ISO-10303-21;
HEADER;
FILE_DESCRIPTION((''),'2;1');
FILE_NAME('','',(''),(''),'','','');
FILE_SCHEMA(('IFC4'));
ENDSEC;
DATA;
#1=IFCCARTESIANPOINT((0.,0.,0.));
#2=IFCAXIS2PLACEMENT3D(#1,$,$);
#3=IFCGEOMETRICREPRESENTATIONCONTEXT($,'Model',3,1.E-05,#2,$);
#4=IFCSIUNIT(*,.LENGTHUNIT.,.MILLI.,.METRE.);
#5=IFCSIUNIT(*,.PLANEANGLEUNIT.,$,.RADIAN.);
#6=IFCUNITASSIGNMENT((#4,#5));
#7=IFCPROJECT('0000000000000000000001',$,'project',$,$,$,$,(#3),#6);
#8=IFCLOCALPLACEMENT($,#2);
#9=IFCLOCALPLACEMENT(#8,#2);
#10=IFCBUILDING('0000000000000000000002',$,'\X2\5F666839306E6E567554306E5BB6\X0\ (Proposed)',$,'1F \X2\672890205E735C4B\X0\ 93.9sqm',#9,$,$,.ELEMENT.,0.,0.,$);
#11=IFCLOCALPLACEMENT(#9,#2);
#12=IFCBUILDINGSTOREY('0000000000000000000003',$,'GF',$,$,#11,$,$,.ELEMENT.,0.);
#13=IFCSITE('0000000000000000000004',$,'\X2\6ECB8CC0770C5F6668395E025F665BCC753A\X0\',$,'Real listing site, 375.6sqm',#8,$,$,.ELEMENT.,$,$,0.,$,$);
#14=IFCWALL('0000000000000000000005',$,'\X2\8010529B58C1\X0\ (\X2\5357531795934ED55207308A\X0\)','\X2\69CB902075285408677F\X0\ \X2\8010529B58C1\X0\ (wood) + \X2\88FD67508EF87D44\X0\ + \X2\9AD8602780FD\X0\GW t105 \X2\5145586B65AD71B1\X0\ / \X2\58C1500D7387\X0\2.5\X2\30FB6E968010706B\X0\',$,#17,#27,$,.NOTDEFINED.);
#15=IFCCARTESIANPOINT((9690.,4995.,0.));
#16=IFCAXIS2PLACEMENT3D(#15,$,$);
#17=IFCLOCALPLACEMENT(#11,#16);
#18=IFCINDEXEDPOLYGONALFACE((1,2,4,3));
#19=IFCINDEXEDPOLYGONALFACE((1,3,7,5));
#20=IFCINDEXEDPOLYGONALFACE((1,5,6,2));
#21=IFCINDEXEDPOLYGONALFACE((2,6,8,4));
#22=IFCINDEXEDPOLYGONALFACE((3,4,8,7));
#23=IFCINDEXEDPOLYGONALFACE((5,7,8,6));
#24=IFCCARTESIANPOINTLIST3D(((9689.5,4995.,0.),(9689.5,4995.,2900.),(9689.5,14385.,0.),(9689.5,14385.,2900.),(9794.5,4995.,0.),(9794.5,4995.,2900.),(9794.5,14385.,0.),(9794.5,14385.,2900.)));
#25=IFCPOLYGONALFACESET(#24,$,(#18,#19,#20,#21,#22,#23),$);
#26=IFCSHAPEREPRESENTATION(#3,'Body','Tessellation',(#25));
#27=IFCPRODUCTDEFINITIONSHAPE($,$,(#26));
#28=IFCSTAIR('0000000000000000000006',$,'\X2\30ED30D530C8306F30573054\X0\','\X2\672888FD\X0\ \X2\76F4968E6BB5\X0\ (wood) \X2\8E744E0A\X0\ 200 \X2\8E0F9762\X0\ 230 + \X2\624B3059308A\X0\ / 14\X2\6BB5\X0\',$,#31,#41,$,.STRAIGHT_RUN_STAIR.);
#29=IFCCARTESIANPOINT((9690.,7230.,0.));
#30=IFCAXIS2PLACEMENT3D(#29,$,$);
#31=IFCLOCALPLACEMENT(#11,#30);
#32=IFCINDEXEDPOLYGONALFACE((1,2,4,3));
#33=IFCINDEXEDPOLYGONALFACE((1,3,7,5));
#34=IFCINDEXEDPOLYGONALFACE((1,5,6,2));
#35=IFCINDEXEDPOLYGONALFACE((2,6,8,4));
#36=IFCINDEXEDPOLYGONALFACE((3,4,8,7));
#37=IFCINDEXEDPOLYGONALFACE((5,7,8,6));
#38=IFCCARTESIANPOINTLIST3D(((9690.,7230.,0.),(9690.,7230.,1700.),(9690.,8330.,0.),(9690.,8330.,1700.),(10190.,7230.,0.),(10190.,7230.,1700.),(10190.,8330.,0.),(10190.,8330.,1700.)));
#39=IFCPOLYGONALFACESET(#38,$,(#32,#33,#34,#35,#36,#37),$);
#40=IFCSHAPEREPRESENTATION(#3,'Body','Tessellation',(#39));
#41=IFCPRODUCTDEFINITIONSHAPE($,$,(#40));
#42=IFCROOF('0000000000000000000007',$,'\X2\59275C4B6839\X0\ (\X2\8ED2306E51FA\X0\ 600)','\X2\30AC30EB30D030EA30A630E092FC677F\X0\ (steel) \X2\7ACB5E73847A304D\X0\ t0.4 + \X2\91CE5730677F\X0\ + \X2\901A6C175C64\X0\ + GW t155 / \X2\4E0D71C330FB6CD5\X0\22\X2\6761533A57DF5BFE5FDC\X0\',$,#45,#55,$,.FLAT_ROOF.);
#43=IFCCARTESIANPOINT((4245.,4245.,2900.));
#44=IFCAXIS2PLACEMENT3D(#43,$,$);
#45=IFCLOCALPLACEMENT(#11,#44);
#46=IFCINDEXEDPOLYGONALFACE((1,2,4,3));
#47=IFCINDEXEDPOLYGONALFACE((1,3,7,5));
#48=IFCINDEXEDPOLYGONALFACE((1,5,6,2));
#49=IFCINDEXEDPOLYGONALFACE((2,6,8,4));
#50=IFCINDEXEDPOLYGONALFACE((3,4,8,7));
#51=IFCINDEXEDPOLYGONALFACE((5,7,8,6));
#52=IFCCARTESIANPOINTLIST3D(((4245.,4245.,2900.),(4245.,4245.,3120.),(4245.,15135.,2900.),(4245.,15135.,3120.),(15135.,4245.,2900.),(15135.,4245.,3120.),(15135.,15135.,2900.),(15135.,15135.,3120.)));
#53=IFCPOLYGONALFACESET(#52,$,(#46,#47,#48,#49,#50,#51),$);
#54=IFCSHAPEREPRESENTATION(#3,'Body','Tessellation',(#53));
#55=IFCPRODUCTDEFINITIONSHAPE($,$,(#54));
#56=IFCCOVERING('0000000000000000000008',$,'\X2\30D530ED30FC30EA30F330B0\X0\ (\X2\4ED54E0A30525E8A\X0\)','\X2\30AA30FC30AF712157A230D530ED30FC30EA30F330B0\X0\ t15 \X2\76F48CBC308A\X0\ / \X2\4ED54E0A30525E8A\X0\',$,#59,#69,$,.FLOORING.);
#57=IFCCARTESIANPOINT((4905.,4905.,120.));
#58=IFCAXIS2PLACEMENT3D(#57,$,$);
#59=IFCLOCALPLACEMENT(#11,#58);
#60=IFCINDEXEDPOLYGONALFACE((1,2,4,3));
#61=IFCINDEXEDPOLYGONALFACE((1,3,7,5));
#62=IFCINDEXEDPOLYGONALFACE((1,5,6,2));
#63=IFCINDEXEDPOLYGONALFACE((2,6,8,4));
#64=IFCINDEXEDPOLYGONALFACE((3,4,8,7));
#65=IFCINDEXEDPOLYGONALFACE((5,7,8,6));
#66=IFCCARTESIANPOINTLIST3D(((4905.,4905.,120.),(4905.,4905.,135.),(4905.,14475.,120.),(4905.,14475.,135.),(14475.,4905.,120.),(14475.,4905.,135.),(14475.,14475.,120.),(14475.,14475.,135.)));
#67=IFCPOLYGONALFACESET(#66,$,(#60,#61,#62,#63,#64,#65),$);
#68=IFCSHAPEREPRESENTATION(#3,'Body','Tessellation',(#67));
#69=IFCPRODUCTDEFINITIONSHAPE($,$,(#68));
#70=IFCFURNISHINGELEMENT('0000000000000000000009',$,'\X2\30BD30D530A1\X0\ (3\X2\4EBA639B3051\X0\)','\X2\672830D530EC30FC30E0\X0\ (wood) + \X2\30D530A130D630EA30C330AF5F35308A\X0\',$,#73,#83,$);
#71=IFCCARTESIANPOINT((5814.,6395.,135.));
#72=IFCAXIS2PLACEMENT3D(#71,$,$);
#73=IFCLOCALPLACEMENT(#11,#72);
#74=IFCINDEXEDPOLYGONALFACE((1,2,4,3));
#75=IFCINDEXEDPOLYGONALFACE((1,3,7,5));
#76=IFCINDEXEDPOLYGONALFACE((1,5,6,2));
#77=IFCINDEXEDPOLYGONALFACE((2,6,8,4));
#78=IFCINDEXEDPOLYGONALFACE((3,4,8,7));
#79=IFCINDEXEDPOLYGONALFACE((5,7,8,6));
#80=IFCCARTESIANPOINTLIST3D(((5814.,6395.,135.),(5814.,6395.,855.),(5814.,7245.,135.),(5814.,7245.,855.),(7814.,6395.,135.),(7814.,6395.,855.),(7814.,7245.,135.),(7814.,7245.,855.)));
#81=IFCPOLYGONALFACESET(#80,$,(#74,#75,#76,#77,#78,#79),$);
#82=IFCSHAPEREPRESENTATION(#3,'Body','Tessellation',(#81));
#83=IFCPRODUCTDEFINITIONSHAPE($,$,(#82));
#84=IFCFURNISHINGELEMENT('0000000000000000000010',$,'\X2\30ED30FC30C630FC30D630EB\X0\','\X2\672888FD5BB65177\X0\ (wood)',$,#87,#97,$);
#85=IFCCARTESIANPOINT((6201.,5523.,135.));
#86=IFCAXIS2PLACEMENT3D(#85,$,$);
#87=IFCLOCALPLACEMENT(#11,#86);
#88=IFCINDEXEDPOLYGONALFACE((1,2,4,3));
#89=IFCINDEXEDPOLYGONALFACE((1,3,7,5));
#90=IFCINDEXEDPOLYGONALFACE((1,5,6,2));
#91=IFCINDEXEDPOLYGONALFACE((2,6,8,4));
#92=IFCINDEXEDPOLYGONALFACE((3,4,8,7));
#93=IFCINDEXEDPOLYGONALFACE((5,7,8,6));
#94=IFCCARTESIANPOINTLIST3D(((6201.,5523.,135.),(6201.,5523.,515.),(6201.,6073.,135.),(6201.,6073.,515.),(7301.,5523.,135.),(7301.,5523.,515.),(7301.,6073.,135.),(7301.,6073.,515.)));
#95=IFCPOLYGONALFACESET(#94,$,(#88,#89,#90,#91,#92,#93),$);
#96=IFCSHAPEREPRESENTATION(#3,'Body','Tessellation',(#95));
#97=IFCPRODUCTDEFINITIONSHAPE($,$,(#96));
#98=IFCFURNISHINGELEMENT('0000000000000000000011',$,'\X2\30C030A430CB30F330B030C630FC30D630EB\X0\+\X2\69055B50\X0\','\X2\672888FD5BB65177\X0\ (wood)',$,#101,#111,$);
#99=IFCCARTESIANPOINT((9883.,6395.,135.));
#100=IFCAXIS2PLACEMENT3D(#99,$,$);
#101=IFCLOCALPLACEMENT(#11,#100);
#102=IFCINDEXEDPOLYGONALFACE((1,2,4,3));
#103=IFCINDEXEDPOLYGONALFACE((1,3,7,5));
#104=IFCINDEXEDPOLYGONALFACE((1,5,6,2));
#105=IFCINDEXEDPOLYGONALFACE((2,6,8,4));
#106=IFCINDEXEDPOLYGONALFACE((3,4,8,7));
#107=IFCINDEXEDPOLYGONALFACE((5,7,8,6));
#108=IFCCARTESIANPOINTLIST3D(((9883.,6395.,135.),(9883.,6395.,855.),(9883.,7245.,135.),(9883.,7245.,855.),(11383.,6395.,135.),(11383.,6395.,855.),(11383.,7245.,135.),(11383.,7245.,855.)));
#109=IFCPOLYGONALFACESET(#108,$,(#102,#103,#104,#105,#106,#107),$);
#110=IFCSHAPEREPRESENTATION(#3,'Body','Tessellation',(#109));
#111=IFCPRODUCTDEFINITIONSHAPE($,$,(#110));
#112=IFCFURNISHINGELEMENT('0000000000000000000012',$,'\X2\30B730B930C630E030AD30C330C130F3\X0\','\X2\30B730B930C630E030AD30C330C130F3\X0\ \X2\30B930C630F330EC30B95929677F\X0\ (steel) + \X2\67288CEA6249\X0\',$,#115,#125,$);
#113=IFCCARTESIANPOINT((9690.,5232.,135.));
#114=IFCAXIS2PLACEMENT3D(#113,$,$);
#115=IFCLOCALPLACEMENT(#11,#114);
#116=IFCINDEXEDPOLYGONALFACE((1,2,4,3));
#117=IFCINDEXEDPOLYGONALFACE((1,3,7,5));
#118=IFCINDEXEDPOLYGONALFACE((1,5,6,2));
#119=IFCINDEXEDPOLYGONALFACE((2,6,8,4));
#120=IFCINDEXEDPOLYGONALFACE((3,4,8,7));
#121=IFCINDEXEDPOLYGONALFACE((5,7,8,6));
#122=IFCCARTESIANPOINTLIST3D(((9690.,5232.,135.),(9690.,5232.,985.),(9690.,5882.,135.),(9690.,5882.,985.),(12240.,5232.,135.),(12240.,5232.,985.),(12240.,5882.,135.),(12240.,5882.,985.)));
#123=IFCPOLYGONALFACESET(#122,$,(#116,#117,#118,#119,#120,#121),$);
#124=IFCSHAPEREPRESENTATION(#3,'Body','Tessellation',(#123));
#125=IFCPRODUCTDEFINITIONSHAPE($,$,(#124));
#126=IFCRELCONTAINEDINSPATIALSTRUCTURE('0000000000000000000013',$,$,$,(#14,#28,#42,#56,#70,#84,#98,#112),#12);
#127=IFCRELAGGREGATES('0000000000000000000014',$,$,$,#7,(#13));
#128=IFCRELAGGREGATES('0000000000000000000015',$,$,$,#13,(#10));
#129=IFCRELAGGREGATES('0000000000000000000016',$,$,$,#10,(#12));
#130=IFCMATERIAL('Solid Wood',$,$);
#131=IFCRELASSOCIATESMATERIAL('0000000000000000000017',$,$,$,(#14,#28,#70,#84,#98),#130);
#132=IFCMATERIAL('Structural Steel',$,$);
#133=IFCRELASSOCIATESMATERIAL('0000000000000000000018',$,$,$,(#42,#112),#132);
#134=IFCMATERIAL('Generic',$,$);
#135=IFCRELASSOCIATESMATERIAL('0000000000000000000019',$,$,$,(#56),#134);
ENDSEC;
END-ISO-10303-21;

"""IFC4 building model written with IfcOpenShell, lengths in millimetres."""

from ifc_helpers import new_model, si_unit, frame, frame_2d, origin, place, context, project, spatial, rectangle, extrude, material, element, save


model = new_model("IFC4")

# Units and contexts
model_context = context("Model", 3, precision=1e-05, world=origin())
ifc_project = project(units=[si_unit("LENGTHUNIT", "METRE", prefix="MILLI"), si_unit("PLANEANGLEUNIT", "RADIAN")], contexts=[model_context])

# Site, building, storey
site_placement = place(None, origin())
site = spatial("IfcSite", under=ifc_project, at=site_placement, Name="滋賀県彦根市彦富町", ObjectType="Real listing site, 375.6sqm", CompositionType="ELEMENT", RefElevation=0.0)
building_placement = place(site_placement, origin())
building = spatial("IfcBuilding", under=site, at=building_placement, Name="彦根の湖畔の家 (Proposed)", ObjectType="1F 木造平屋 93.9sqm", CompositionType="ELEMENT", ElevationOfRefHeight=0.0, ElevationOfTerrain=0.0)
storey_placement = place(building_placement, origin())
storey = spatial("IfcBuildingStorey", under=building, at=storey_placement, Name="GF", CompositionType="ELEMENT", Elevation=0.0)

# Shared definitions
ifc_material_1 = material(Name="Solid Wood")

# Wall
wall_1_placement = place(storey_placement, frame((9690.0, 4995.0, 0.0)))
element("IfcWall", 1, at=wall_1_placement, inside=storey, material=ifc_material_1, Name="耐力壁 (南北間仕切り)", Description="構造用合板 耐力壁 (wood) + 製材軸組 + 高性能GW t105 充填断熱 / 壁倍率2.5・準耐火", PredefinedType="NOTDEFINED", context=model_context, shape_type="SweptSolid", body=[
    extrude(rectangle(XDim=105.0, YDim=9390.0, at=frame_2d((52.0, 4695.0))), frame((9690.0, 4995.0, 0.0)), (0.0, 0.0, 1.0), 2900.0),
])

# Stair
stair_placement = place(storey_placement, frame((9690.0, 7230.0, 0.0)))
element("IfcStair", 2, at=stair_placement, inside=storey, material=ifc_material_1, Name="ロフトはしご", Description="木製 直階段 (wood) 蹴上 200 踏面 230 + 手すり / 14段", PredefinedType="STRAIGHT_RUN_STAIR", context=model_context, shape_type="SweptSolid", body=[
    extrude(rectangle(XDim=500.0, YDim=1100.0, at=frame_2d((250.0, 550.0))), frame((9690.0, 7230.0, 0.0)), (0.0, 0.0, 1.0), 1700.0),
])

# Roof
ifc_material_2 = material(Name="Structural Steel")
roof_placement = place(storey_placement, frame((4245.0, 4245.0, 2900.0)))
element("IfcRoof", 3, at=roof_placement, inside=storey, material=ifc_material_2, Name="大屋根 (軒の出 600)", Description="ガルバリウム鋼板 (steel) 立平葺き t0.4 + 野地板 + 通気層 + GW t155 / 不燃・法22条区域対応", PredefinedType="FLAT_ROOF", context=model_context, shape_type="SweptSolid", body=[
    extrude(rectangle(XDim=10890.0, YDim=10890.0, at=frame_2d((5445.0, 5445.0))), frame((4245.0, 4245.0, 2900.0)), (0.0, 0.0, 1.0), 220.0),
])

# Covering
ifc_material_3 = material(Name="Generic")
covering_placement = place(storey_placement, frame((4905.0, 4905.0, 120.0)))
element("IfcCovering", 4, at=covering_placement, inside=storey, material=ifc_material_3, Name="フローリング (仕上げ床)", Description="オーク無垢フローリング t15 直貼り / 仕上げ床", PredefinedType="FLOORING", context=model_context, shape_type="SweptSolid", body=[
    extrude(rectangle(XDim=9570.0, YDim=9570.0, at=frame_2d((4785.0, 4785.0))), frame((4905.0, 4905.0, 120.0)), (0.0, 0.0, 1.0), 15.0),
])

# Furnishing elements
furnishing_1_placement = place(storey_placement, frame((5814.0, 6395.0, 135.0)))
element("IfcFurnishingElement", 5, at=furnishing_1_placement, inside=storey, material=ifc_material_1, Name="ソファ (3人掛け)", Description="木フレーム (wood) + ファブリック張り", context=model_context, shape_type="SweptSolid", body=[
    extrude(rectangle(XDim=2000.0, YDim=850.0, at=frame_2d((1000.0, 425.0))), frame((5814.0, 6395.0, 135.0)), (0.0, 0.0, 1.0), 720.0),
])
furnishing_2_placement = place(storey_placement, frame((6201.0, 5523.0, 135.0)))
element("IfcFurnishingElement", 6, at=furnishing_2_placement, inside=storey, material=ifc_material_1, Name="ローテーブル", Description="木製家具 (wood)", context=model_context, shape_type="SweptSolid", body=[
    extrude(rectangle(XDim=1100.0, YDim=550.0, at=frame_2d((550.0, 275.0))), frame((6201.0, 5523.0, 135.0)), (0.0, 0.0, 1.0), 380.0),
])
furnishing_3_placement = place(storey_placement, frame((9883.0, 6395.0, 135.0)))
element("IfcFurnishingElement", 7, at=furnishing_3_placement, inside=storey, material=ifc_material_1, Name="ダイニングテーブル+椅子", Description="木製家具 (wood)", context=model_context, shape_type="SweptSolid", body=[
    extrude(rectangle(XDim=1500.0, YDim=850.0, at=frame_2d((750.0, 425.0))), frame((9883.0, 6395.0, 135.0)), (0.0, 0.0, 1.0), 720.0),
])
furnishing_4_placement = place(storey_placement, frame((9690.0, 5232.0, 135.0)))
element("IfcFurnishingElement", 8, at=furnishing_4_placement, inside=storey, material=ifc_material_2, Name="システムキッチン", Description="システムキッチン ステンレス天板 (steel) + 木質扉", context=model_context, shape_type="SweptSolid", body=[
    extrude(rectangle(XDim=2550.0, YDim=650.0, at=frame_2d((1275.0, 325.0))), frame((9690.0, 5232.0, 135.0)), (0.0, 0.0, 1.0), 850.0),
])

save(model, "model.ifc")
